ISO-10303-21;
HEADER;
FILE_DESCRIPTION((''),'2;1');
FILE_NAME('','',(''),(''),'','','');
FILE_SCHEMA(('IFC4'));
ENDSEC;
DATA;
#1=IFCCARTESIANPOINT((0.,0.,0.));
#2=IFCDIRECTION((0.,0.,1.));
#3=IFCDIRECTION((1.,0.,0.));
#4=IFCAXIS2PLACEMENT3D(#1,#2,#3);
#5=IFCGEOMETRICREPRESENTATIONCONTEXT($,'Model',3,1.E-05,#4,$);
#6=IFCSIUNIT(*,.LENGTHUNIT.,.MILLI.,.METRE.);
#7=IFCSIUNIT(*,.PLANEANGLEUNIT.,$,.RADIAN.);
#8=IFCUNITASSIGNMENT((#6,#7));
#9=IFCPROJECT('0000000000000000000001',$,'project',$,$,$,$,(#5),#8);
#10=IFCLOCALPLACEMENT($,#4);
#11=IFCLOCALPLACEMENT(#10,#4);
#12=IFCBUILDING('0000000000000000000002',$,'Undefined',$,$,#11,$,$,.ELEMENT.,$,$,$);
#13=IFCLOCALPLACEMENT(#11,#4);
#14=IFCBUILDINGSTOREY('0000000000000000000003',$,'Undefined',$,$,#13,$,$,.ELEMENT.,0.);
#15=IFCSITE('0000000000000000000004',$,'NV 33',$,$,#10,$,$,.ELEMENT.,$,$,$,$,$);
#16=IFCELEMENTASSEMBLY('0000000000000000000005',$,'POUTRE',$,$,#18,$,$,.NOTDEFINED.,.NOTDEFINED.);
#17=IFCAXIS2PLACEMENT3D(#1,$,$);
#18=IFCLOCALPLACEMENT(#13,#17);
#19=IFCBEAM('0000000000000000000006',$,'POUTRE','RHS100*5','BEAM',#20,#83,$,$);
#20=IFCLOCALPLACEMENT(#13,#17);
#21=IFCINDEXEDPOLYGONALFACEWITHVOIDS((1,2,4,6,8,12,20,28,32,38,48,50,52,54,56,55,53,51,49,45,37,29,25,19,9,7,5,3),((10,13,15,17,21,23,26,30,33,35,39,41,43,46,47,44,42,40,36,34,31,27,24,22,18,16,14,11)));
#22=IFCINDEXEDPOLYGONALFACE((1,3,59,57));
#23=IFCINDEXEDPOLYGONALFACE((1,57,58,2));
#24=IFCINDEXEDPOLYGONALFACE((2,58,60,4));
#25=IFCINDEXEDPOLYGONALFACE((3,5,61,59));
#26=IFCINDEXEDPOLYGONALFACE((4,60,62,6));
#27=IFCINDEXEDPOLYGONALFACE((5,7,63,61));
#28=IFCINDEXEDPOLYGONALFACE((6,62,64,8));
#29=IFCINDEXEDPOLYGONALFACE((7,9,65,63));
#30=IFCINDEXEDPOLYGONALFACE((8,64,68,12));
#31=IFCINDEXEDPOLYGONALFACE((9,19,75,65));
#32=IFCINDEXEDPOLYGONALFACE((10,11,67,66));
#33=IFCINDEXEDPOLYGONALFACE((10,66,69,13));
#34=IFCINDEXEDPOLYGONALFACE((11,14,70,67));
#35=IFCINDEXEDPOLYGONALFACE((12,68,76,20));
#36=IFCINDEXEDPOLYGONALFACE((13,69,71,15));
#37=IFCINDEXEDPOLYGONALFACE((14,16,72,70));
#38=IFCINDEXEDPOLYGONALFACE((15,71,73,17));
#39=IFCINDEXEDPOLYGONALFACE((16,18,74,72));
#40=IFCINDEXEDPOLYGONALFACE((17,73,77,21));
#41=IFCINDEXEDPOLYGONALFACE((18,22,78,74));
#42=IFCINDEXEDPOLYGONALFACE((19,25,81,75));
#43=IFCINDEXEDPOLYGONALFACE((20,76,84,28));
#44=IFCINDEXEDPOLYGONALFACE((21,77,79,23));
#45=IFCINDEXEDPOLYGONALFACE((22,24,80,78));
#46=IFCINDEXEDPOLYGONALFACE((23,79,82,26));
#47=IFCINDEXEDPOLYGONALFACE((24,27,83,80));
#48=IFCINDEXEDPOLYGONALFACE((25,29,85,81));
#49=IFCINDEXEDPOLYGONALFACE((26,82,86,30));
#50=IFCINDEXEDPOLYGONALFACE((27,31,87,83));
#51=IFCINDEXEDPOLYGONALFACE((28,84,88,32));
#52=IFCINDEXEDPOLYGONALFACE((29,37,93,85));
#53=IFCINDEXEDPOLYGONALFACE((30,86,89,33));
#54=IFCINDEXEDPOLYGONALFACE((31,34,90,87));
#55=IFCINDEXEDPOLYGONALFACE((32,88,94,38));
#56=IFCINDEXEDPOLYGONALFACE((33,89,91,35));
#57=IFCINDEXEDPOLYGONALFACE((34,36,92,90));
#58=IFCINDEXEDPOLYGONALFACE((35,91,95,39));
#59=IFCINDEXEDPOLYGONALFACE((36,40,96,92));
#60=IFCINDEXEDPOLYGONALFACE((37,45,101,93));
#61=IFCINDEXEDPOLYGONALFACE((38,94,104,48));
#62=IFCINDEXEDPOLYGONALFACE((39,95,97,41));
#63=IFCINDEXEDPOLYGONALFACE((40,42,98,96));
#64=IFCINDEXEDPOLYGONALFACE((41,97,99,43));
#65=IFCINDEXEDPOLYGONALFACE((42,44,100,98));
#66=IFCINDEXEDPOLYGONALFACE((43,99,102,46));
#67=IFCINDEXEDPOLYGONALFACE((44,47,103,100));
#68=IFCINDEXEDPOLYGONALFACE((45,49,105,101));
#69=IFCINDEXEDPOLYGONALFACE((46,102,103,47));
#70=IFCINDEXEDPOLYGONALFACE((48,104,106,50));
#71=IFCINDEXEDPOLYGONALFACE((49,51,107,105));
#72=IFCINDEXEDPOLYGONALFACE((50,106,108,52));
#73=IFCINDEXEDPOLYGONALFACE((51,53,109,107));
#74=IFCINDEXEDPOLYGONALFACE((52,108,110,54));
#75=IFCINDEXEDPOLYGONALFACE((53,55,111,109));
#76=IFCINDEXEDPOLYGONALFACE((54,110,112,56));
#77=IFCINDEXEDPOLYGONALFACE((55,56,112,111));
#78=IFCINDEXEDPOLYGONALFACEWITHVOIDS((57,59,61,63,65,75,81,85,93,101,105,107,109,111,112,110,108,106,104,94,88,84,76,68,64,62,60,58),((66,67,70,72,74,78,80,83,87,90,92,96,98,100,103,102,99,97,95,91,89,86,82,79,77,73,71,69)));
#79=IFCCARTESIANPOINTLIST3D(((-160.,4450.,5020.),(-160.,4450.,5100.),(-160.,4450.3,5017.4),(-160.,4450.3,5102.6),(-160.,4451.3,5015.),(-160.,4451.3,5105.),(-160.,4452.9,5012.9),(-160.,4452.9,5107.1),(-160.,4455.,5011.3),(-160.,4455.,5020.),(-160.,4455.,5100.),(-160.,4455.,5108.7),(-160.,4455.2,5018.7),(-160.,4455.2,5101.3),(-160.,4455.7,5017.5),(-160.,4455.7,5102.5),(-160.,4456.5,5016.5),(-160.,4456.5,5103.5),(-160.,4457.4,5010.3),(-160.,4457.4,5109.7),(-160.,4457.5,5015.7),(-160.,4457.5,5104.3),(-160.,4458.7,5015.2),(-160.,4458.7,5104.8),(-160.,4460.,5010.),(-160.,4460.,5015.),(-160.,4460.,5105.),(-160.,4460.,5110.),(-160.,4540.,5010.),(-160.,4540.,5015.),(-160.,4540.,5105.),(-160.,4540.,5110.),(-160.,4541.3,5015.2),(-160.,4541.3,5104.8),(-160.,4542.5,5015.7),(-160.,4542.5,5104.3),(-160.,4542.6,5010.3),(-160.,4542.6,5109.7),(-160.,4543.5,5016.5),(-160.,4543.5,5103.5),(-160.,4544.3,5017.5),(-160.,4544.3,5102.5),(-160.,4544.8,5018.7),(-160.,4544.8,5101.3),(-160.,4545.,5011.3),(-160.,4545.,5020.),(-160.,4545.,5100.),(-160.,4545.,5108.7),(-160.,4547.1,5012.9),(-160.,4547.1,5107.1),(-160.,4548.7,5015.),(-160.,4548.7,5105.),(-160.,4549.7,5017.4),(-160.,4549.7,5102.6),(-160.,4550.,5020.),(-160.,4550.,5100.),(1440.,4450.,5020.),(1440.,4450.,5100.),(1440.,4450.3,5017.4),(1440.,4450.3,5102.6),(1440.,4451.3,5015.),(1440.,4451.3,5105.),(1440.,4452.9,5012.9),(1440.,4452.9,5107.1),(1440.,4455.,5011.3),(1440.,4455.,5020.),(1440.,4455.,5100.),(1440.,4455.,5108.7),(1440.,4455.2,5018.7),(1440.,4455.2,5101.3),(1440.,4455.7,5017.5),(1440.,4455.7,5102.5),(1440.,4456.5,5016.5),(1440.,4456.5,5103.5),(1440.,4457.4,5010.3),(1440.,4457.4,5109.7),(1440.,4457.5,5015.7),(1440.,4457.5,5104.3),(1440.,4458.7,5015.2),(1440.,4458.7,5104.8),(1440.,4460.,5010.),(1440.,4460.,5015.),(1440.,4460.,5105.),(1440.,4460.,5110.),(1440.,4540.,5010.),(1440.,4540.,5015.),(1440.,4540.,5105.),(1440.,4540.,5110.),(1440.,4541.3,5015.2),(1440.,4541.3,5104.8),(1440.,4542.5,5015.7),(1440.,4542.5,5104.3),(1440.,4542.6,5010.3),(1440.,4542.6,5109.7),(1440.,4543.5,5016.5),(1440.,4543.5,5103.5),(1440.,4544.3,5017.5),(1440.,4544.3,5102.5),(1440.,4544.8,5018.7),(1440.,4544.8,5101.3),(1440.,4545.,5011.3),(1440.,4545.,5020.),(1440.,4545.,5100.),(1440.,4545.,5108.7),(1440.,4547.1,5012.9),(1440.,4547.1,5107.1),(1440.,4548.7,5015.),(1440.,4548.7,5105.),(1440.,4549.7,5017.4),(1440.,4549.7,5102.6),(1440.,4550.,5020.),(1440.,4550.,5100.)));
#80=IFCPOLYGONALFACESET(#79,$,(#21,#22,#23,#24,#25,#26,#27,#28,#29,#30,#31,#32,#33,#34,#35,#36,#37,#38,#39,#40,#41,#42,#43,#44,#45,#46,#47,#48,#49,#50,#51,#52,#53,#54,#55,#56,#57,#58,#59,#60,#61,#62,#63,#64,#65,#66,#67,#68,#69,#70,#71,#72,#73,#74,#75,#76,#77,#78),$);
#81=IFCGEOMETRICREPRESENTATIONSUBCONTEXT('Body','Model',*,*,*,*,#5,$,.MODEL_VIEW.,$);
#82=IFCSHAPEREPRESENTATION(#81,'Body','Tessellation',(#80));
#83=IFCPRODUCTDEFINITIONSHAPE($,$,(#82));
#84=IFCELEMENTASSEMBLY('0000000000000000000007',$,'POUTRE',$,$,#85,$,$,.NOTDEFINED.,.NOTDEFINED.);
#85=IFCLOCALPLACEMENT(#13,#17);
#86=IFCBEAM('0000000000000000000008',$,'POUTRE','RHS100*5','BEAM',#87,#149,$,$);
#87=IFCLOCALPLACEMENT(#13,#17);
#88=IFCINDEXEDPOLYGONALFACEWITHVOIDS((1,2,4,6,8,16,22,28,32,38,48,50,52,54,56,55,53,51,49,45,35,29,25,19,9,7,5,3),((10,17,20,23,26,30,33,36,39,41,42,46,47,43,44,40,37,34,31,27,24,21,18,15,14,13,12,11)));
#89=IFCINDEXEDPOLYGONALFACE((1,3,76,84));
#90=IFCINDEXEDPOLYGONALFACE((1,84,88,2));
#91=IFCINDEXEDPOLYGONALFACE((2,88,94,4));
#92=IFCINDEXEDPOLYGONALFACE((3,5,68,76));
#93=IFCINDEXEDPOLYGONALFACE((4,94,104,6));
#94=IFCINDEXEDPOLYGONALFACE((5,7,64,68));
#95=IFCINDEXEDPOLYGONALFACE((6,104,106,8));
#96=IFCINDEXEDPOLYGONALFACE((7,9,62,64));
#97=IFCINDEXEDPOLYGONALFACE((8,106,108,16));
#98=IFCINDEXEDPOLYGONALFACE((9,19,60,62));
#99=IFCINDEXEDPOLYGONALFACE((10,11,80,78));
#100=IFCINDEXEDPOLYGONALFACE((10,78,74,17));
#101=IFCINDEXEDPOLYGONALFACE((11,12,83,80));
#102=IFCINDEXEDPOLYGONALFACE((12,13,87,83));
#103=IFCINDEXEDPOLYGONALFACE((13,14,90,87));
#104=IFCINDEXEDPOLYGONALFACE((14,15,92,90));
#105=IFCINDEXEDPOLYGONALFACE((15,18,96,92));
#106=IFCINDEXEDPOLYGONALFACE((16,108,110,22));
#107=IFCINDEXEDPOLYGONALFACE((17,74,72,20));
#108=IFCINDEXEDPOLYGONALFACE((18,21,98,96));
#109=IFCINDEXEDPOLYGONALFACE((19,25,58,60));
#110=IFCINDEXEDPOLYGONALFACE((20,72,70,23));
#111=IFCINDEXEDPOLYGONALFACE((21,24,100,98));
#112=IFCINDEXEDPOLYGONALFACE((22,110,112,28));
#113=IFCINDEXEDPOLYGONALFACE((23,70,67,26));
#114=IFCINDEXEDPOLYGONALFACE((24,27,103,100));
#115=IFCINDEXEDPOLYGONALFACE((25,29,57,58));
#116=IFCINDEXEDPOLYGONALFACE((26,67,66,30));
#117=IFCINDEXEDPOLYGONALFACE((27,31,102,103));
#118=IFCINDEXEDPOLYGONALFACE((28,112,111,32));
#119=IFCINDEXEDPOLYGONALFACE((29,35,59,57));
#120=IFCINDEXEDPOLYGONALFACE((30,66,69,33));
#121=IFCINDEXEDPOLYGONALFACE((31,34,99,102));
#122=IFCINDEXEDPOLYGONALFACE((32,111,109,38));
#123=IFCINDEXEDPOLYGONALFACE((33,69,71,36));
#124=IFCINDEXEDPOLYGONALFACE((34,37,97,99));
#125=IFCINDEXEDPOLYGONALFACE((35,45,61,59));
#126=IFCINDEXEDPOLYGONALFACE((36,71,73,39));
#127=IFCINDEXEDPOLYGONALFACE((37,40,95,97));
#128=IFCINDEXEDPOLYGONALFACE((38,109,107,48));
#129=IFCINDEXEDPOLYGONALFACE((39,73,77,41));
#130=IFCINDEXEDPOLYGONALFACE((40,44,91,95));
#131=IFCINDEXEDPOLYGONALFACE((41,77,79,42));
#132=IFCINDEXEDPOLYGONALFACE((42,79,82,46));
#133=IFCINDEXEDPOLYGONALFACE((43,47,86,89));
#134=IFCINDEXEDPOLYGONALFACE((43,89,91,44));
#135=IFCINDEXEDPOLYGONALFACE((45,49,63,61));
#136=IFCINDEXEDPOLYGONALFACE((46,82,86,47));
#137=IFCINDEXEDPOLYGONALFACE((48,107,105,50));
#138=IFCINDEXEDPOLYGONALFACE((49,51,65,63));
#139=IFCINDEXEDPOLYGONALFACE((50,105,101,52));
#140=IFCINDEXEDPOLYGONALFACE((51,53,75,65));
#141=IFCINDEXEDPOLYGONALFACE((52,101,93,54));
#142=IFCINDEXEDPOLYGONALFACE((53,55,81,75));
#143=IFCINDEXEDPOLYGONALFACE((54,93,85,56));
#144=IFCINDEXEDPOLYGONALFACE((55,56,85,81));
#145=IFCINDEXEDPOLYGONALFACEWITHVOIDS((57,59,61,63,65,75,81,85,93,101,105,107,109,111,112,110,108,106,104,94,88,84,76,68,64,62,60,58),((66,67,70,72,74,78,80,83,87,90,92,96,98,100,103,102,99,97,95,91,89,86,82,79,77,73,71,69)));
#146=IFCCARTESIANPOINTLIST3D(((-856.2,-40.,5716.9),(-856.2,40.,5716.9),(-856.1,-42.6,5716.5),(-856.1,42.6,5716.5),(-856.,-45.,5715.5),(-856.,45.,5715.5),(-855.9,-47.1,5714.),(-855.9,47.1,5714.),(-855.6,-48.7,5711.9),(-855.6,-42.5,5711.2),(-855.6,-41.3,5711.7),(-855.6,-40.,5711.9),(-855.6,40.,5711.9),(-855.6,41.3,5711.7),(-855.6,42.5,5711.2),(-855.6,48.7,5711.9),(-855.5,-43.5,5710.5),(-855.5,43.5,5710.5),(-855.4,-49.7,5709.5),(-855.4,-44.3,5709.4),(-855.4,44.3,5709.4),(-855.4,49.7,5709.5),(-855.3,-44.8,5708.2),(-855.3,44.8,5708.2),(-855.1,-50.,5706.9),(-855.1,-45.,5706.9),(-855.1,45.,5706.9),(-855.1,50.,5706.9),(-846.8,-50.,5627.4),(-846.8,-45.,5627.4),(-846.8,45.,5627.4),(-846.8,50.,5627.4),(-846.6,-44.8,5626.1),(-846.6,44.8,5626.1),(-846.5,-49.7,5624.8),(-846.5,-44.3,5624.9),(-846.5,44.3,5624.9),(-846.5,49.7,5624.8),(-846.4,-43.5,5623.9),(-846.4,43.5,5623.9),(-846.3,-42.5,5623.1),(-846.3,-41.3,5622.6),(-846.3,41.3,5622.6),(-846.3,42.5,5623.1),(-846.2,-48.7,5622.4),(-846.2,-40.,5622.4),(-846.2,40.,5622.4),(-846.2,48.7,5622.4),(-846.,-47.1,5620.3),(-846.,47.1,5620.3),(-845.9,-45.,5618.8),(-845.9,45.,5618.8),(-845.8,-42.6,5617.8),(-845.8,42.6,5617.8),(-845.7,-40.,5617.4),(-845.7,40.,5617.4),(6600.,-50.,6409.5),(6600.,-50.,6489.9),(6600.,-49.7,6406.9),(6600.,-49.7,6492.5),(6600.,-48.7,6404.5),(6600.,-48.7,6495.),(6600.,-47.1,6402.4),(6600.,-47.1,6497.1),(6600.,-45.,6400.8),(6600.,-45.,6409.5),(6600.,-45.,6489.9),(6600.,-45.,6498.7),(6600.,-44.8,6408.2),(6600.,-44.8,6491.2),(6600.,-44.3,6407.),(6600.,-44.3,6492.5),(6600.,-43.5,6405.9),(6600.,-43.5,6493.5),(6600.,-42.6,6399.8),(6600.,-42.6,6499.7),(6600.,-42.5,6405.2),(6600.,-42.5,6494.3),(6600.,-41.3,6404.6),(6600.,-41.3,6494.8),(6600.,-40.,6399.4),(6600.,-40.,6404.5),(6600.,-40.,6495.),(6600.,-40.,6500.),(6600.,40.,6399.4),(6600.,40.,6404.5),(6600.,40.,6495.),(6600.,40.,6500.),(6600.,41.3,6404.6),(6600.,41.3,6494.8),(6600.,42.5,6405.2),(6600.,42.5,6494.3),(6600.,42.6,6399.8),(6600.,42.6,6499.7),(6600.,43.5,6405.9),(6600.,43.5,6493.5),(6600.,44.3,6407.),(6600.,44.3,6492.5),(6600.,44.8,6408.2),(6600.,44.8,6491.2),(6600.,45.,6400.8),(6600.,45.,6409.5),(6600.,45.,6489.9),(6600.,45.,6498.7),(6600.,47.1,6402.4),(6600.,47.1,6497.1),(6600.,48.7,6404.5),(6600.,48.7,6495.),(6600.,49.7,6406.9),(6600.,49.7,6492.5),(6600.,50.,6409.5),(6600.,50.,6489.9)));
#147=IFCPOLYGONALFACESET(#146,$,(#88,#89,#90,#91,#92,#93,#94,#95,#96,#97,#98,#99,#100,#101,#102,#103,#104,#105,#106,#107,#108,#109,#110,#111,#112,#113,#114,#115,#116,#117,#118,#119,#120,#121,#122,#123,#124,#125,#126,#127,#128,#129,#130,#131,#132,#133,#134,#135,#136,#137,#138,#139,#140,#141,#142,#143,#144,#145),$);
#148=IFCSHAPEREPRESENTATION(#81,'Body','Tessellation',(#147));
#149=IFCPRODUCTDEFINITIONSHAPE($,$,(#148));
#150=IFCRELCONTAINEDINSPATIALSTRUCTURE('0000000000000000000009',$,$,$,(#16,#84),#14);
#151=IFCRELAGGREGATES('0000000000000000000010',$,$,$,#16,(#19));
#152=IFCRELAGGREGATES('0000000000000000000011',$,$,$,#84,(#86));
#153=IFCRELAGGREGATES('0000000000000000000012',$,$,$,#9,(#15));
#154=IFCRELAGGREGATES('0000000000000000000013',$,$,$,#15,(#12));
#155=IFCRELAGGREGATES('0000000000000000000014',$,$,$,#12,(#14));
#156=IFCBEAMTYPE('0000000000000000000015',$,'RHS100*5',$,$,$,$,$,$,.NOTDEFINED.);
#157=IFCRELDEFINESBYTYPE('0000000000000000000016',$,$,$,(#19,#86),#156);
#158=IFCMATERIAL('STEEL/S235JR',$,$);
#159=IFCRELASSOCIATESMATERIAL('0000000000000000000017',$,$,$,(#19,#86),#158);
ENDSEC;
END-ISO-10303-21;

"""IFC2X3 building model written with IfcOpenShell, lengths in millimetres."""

from ifc_helpers import new_model, si_unit, frame, origin_with_axes, origin_2d_with_axis, place, context, subcontext, project, spatial, hollow_rectangle, extrude, clip, halfspace, material, type_object, element, aggregate, save


model = new_model("IFC2X3")

# Units and contexts
model_context = context("Model", 3, precision=1e-05, world=origin_with_axes())
body_context = subcontext(model_context, "Body", "Model", "MODEL_VIEW")
ifc_project = project(units=[si_unit("LENGTHUNIT", "METRE", prefix="MILLI"), si_unit("PLANEANGLEUNIT", "RADIAN")], contexts=[model_context])

# Site, building, storey
site_placement = place(None, origin_with_axes())
site = spatial("IfcSite", under=ifc_project, at=site_placement, Name="NV 33", CompositionType="ELEMENT")
building_placement = place(site_placement, origin_with_axes())
building = spatial("IfcBuilding", under=site, at=building_placement, Name="Undefined", CompositionType="ELEMENT")
storey_placement = place(building_placement, origin_with_axes())
storey = spatial("IfcBuildingStorey", under=building, at=storey_placement, Name="Undefined", CompositionType="ELEMENT", Elevation=0.0)

# Shared definitions
ifc_material_1 = material(Name="STEEL/S235JR")

# Element assemblies, beams
assembly_1_placement = place(storey_placement, origin_with_axes())
assembly_1 = element("IfcElementAssembly", 1, at=assembly_1_placement, inside=storey, Name="POUTRE", AssemblyPlace="NOTDEFINED", PredefinedType="NOTDEFINED")
beam_type_1 = type_object("IfcBeamType", Name="RHS100*5", PredefinedType="NOTDEFINED")
beam_1_placement = place(assembly_1_placement, frame((-160.0, 4500.0, 5060.0), z_axis=(0.0, -1.0, 0.0), x_axis=(1.0, 0.0, 0.0)))
beam_1 = element("IfcBeam", 2, at=beam_1_placement, type_object=beam_type_1, material=ifc_material_1, Name="POUTRE", Description="RHS100*5", ObjectType="BEAM", context=body_context, shape_type="SweptSolid", body=[
    extrude(hollow_rectangle(XDim=100.0, YDim=100.0, WallThickness=5.0, InnerFilletRadius=5.0, OuterFilletRadius=10.0, at=origin_2d_with_axis()), frame((1600.0, 0.0, 0.0), z_axis=(-1.0, 0.0, 0.0), x_axis=(0.0, -1.0, 0.0)), (0.0, 0.0, 1.0), 1600.0),
])
aggregate(assembly_1, [beam_1])
assembly_2_placement = place(storey_placement, origin_with_axes())
assembly_2 = element("IfcElementAssembly", 3, at=assembly_2_placement, inside=storey, Name="POUTRE", AssemblyPlace="NOTDEFINED", PredefinedType="NOTDEFINED")
beam_2_placement = place(assembly_2_placement, frame((-850.9, 0.0, 5667.2), z_axis=(0.104455, 0.0, -0.99453), x_axis=(0.99453, 0.0, 0.104455)))
beam_2 = element("IfcBeam", 4, at=beam_2_placement, type_object=beam_type_1, material=ifc_material_1, Name="POUTRE", Description="RHS100*5", ObjectType="BEAM", context=body_context, shape_type="Clipping", body=[
    clip(extrude(hollow_rectangle(XDim=100.0, YDim=100.0, WallThickness=5.0, InnerFilletRadius=5.0, OuterFilletRadius=10.0, at=origin_2d_with_axis()), frame((7527.2, 0.0, 0.0), z_axis=(-1.0, 0.0, 0.0), x_axis=(0.0, -1.0, 0.0)), (0.0, 0.0, 1.0), 7527.2), halfspace(frame((7497.2, -50.0, -50.0), z_axis=(0.99453, 0.0, 0.104455), x_axis=(-0.104455, 0.0, 0.99453)), False)),
])
aggregate(assembly_2, [beam_2])

save(model, "model.ifc")
